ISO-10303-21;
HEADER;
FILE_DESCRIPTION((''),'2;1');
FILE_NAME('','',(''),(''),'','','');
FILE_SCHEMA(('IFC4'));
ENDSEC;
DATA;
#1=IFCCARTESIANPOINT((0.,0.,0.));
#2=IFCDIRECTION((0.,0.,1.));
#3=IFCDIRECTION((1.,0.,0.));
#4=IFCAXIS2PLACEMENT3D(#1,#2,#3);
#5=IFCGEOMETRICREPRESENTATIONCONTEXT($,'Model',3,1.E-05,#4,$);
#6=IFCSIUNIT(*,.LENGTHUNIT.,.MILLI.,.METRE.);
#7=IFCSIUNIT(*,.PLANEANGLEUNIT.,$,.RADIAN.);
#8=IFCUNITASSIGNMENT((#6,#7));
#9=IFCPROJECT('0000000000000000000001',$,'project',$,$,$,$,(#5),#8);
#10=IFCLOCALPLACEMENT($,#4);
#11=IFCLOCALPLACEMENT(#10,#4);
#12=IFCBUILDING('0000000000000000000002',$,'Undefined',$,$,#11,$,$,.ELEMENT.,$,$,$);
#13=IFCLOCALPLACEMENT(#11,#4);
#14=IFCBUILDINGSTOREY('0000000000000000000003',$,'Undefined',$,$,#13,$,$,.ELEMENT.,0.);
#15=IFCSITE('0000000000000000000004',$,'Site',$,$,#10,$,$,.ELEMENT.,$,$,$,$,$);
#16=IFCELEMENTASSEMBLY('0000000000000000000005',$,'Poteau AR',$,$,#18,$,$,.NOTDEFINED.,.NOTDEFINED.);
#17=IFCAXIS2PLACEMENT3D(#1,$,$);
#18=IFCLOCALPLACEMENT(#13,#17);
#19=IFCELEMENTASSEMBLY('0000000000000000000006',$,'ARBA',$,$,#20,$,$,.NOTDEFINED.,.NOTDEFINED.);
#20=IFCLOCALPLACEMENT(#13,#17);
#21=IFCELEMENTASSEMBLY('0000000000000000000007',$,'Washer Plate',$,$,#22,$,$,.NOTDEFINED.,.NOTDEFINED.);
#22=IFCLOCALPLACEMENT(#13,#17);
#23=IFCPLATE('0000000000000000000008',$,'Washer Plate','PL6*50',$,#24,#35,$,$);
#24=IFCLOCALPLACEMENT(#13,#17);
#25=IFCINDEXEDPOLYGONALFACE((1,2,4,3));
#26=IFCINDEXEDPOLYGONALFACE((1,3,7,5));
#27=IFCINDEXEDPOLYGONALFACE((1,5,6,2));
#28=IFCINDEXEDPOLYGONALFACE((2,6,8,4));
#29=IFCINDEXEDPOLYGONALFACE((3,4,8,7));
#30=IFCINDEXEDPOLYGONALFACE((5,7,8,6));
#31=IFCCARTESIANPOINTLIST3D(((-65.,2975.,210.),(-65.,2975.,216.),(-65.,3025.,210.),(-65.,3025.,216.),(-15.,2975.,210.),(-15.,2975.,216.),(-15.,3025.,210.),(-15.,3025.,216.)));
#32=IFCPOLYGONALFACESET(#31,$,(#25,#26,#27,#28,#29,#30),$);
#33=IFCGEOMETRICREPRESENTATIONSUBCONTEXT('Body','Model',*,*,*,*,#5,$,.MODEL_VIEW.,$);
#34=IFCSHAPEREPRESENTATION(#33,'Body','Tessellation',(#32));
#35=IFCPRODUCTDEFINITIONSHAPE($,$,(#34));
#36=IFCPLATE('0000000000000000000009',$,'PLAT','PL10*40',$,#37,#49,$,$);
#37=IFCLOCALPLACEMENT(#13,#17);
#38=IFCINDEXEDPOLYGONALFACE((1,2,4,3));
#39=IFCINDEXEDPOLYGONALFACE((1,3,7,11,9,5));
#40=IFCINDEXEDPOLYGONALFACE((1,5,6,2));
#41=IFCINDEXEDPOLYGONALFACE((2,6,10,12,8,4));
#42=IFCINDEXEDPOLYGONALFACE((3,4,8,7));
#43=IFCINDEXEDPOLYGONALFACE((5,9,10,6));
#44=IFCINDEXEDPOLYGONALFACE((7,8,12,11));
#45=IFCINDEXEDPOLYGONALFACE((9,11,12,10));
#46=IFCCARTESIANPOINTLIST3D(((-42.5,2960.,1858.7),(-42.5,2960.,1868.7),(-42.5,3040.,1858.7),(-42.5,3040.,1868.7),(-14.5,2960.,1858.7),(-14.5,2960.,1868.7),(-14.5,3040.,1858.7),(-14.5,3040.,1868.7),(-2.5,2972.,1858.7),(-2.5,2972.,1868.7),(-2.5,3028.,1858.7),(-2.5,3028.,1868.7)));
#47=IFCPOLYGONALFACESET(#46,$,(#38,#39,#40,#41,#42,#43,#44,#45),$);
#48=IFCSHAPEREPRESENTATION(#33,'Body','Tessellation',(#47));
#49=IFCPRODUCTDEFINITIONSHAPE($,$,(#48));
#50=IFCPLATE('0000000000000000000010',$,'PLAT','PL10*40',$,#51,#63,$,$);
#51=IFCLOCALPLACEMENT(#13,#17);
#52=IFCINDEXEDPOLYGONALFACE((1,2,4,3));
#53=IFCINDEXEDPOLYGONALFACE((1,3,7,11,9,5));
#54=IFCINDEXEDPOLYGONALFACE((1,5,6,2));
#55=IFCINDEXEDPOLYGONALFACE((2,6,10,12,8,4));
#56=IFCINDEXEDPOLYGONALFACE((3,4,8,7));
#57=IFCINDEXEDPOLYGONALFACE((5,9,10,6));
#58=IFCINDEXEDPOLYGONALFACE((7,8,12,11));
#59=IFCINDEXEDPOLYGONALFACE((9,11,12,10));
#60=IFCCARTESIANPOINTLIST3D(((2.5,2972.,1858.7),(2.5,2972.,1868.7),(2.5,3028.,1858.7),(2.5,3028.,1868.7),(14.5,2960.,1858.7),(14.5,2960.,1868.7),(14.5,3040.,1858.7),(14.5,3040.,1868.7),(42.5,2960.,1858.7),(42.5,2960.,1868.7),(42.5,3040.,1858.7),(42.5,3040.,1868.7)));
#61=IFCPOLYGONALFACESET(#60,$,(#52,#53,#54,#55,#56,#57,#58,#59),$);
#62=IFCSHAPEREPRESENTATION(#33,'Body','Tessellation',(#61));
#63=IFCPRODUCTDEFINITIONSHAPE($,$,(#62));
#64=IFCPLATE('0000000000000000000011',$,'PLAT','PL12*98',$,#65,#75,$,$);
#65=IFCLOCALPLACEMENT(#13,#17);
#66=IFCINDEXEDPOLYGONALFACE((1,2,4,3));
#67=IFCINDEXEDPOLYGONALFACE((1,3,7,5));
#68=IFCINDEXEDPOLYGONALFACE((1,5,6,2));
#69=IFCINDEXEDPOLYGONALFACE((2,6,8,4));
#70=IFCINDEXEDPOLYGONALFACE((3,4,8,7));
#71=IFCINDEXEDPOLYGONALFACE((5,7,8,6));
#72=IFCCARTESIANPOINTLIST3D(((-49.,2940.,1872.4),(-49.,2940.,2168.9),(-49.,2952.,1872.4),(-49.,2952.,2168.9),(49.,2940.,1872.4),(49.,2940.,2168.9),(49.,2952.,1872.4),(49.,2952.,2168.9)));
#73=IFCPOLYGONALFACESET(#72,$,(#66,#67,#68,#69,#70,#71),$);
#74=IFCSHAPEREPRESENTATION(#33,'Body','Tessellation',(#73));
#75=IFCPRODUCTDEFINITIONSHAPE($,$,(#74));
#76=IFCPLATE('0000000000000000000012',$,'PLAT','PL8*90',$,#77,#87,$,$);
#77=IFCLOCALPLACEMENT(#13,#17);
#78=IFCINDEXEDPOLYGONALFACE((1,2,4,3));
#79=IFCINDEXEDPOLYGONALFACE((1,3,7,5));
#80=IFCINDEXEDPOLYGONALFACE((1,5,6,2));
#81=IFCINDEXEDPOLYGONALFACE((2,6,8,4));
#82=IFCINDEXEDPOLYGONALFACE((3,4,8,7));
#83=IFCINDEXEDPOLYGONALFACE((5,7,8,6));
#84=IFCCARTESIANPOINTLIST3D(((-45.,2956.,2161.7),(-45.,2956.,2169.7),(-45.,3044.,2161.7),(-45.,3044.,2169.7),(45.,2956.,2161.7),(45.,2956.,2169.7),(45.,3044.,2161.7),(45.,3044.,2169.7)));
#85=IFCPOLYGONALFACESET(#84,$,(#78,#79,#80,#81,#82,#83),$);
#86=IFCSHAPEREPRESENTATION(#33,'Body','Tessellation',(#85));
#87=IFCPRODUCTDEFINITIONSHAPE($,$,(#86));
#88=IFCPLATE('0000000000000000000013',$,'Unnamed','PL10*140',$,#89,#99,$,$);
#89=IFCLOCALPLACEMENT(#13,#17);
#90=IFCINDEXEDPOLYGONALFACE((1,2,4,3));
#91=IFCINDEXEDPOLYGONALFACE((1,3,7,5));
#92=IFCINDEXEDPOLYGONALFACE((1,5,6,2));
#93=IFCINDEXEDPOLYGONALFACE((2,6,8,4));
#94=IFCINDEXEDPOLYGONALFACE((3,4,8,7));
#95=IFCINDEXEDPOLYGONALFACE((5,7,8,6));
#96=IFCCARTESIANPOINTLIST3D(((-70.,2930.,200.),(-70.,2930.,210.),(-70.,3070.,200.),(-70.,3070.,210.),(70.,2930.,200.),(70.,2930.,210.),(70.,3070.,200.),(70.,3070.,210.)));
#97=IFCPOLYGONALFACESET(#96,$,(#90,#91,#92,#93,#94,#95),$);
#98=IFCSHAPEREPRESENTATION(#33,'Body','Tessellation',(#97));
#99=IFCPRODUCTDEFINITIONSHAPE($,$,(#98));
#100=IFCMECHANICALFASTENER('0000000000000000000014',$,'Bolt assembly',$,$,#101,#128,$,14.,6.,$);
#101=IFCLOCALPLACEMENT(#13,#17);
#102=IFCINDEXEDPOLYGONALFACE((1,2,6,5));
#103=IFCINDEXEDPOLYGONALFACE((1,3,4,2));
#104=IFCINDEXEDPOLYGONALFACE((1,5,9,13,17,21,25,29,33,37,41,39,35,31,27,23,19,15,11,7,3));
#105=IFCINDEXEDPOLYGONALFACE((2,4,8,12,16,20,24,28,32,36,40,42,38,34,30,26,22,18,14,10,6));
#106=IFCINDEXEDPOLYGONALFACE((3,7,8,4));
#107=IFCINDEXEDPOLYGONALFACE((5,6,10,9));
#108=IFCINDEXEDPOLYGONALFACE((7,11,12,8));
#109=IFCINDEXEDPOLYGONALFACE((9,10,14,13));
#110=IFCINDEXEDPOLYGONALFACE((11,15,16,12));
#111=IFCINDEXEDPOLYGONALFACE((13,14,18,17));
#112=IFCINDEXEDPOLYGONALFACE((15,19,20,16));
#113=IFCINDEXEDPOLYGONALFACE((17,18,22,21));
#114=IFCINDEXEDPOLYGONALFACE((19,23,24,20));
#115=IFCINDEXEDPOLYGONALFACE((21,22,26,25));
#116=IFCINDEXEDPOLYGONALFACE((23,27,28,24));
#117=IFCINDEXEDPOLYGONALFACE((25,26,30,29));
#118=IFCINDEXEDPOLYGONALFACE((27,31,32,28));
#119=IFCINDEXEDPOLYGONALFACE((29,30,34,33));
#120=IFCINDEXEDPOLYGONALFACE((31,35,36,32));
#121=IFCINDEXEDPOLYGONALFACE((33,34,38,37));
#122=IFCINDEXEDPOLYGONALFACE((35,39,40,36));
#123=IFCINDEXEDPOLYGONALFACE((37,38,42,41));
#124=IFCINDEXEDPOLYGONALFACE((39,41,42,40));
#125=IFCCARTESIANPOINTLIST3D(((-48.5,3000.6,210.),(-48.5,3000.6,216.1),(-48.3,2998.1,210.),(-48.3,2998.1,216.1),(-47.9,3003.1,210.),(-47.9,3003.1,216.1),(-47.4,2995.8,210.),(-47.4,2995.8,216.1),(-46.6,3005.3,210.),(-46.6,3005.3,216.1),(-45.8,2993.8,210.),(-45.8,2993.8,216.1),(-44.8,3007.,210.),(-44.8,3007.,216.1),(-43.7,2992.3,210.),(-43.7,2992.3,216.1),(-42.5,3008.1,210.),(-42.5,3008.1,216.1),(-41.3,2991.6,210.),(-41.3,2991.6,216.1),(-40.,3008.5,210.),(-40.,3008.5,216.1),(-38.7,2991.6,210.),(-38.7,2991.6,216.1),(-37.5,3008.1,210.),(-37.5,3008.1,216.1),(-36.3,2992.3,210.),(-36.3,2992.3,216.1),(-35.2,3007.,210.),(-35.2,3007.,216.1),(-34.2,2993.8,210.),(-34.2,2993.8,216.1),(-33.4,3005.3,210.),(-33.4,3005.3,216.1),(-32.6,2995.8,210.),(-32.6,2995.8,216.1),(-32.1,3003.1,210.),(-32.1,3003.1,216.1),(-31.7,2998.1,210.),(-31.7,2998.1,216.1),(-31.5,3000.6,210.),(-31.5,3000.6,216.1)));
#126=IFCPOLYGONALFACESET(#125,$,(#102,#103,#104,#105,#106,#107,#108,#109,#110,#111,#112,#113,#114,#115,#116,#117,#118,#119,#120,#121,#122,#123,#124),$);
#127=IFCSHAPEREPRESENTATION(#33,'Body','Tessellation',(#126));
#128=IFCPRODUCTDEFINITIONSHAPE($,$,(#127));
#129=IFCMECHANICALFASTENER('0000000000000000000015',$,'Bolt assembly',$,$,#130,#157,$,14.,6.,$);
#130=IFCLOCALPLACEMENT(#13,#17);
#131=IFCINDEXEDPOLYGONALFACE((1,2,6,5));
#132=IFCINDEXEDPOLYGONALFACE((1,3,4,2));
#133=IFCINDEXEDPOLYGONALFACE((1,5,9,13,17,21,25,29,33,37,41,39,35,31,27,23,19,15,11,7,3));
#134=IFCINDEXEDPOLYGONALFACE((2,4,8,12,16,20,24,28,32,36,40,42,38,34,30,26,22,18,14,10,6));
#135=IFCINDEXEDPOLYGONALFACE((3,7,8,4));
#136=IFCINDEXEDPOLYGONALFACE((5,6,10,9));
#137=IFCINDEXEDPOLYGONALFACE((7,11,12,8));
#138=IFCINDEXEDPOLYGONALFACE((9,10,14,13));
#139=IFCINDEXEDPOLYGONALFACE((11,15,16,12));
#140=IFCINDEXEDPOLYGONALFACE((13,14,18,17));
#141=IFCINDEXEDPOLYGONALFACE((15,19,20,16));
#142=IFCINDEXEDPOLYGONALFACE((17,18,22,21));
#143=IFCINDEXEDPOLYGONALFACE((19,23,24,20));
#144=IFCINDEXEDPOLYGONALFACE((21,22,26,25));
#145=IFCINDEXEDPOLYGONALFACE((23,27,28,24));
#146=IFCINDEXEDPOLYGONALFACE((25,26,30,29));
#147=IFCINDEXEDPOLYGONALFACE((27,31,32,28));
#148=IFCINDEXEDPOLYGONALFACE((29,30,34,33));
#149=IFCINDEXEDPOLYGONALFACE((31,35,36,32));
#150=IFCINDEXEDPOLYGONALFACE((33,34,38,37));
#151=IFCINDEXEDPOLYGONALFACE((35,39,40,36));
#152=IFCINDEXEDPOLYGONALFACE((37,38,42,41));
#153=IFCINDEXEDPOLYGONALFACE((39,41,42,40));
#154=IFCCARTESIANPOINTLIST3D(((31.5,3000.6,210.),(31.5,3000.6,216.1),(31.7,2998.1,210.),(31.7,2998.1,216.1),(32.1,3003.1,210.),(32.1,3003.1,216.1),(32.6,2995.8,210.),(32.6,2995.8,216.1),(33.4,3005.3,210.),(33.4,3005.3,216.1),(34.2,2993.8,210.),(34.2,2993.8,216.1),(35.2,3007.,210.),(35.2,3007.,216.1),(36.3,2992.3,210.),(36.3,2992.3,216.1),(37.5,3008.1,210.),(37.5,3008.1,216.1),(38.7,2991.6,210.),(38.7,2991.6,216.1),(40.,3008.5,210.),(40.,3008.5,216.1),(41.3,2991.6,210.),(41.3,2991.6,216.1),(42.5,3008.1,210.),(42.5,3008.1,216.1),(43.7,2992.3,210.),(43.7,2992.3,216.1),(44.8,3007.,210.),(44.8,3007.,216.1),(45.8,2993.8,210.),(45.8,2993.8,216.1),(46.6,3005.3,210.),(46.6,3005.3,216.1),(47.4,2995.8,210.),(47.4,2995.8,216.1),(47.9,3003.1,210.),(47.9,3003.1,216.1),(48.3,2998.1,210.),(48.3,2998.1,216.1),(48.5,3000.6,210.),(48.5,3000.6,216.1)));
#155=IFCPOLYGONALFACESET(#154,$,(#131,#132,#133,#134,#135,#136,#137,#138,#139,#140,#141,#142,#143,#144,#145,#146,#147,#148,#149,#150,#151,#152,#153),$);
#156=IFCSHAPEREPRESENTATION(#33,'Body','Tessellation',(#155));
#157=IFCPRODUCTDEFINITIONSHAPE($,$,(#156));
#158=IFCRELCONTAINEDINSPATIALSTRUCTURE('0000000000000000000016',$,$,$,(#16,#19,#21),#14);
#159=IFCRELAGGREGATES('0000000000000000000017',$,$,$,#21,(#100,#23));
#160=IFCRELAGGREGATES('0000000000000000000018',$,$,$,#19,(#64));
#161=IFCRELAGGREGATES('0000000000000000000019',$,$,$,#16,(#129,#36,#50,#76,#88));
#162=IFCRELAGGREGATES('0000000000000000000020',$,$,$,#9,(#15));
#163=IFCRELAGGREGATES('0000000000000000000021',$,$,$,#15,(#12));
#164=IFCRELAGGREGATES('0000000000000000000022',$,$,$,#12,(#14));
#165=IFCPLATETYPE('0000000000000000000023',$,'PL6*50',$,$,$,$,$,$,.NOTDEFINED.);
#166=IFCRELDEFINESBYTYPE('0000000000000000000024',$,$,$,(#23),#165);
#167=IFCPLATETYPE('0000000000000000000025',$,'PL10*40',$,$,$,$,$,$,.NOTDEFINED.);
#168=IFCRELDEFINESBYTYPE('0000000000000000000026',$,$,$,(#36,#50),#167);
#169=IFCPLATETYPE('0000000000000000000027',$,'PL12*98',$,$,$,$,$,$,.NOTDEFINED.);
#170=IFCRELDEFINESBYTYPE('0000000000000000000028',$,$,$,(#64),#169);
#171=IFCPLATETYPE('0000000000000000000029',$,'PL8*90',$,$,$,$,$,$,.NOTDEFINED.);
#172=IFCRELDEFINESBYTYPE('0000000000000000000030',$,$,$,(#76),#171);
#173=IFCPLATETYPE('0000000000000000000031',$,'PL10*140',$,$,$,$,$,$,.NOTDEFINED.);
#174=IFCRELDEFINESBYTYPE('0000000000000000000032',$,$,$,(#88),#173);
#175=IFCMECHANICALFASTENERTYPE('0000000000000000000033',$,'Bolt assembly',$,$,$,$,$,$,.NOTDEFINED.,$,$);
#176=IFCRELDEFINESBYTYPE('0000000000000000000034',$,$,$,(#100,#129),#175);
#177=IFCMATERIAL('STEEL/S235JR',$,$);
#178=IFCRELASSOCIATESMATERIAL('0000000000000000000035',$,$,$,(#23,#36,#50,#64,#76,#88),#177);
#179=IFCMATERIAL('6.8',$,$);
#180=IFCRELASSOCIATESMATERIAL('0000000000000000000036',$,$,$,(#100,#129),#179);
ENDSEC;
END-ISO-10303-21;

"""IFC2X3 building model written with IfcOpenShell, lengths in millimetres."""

from ifc_helpers import new_model, si_unit, frame, origin_with_axes, origin_2d_with_axis, place, context, subcontext, project, spatial, polyline, circle, outline, extrude, source, transform, mapped, material, type_object, element, aggregate, save


model = new_model("IFC2X3")

# Units and contexts
model_context = context("Model", 3, precision=1e-05, world=origin_with_axes())
body_context = subcontext(model_context, "Body", "Model", "MODEL_VIEW")
ifc_project = project(units=[si_unit("LENGTHUNIT", "METRE", prefix="MILLI"), si_unit("PLANEANGLEUNIT", "RADIAN")], contexts=[model_context])

# Site, building, storey
site_placement = place(None, origin_with_axes())
site = spatial("IfcSite", under=ifc_project, at=site_placement, Name="Site", CompositionType="ELEMENT")
building_placement = place(site_placement, origin_with_axes())
building = spatial("IfcBuilding", under=site, at=building_placement, Name="Undefined", CompositionType="ELEMENT")
storey_placement = place(building_placement, origin_with_axes())
storey = spatial("IfcBuildingStorey", under=building, at=storey_placement, Name="Undefined", CompositionType="ELEMENT", Elevation=0.0)

# Element assembly
ifc_material_1 = material(Name="STEEL/S235JR")
assembly_1_placement = place(storey_placement, origin_with_axes())
assembly_1 = element("IfcElementAssembly", 1, at=assembly_1_placement, inside=storey, Name="Poteau AR", AssemblyPlace="NOTDEFINED", PredefinedType="NOTDEFINED")

# Element assembly
assembly_2_placement = place(storey_placement, origin_with_axes())
assembly_2 = element("IfcElementAssembly", 2, at=assembly_2_placement, inside=storey, Name="ARBA", AssemblyPlace="NOTDEFINED", PredefinedType="NOTDEFINED")

# Element assembly, plate
assembly_3_placement = place(storey_placement, origin_with_axes())
assembly_3 = element("IfcElementAssembly", 3, at=assembly_3_placement, inside=storey, Name="Washer Plate", AssemblyPlace="NOTDEFINED", PredefinedType="NOTDEFINED")
plate_type_1 = type_object("IfcPlateType", Name="PL6*50", PredefinedType="NOTDEFINED")
plate_1_placement = place(assembly_3_placement, frame((-15.0, 3025.0, 213.0), z_axis=(0.0, 0.0, -1.0), x_axis=(0.0, -1.0, 0.0)))
plate_1 = element("IfcPlate", 4, at=plate_1_placement, type_object=plate_type_1, material=ifc_material_1, Name="Washer Plate", Description="PL6*50", context=body_context, shape_type="SweptSolid", body=[
    extrude(outline(polyline([(0.0, 0.0), (50.0, 0.0), (50.0, 50.0), (0.0, 50.0), (0.0, 0.0)])), frame((0.0, 0.0, -3.0), z_axis=(0.0, 0.0, 1.0), x_axis=(1.0, 0.0, 0.0)), (0.0, 0.0, 1.0), 6.0),
])

# Plates
plate_type_2 = type_object("IfcPlateType", Name="PL10*40", PredefinedType="NOTDEFINED")
plate_2_placement = place(assembly_1_placement, frame((-42.5, 2960.0, 1863.7), z_axis=(0.0, 0.0, 1.0), x_axis=(1.0, 0.0, 0.0)))
plate_2 = element("IfcPlate", 5, at=plate_2_placement, type_object=plate_type_2, material=ifc_material_1, Name="PLAT", Description="PL10*40", context=body_context, shape_type="SweptSolid", body=[
    extrude(outline(polyline([(0.0, 0.0), (28.0, 0.0), (40.0, 12.0), (40.0, 68.0), (28.0, 80.0), (0.0, 80.0), (0.0, 0.0)])), frame((0.0, 0.0, -5.0), z_axis=(0.0, 0.0, 1.0), x_axis=(1.0, 0.0, 0.0)), (0.0, 0.0, 1.0), 10.0),
])
plate_3_placement = place(assembly_1_placement, frame((42.5, 2960.0, 1863.7), z_axis=(0.0, 0.0, -1.0), x_axis=(-1.0, 0.0, 0.0)))
plate_3 = element("IfcPlate", 6, at=plate_3_placement, type_object=plate_type_2, material=ifc_material_1, Name="PLAT", Description="PL10*40", context=body_context, shape_type="SweptSolid", body=[
    extrude(outline(polyline([(0.0, 0.0), (28.0, 0.0), (40.0, 12.0), (40.0, 68.0), (28.0, 80.0), (0.0, 80.0), (0.0, 0.0)])), frame((0.0, 0.0, -5.0), z_axis=(0.0, 0.0, 1.0), x_axis=(1.0, 0.0, 0.0)), (0.0, 0.0, 1.0), 10.0),
])
plate_type_3 = type_object("IfcPlateType", Name="PL12*98", PredefinedType="NOTDEFINED")
plate_4_placement = place(assembly_2_placement, frame((0.0, 2946.0, 1872.4), z_axis=(0.0, -1.0, 0.0), x_axis=(0.0, 0.0, 1.0)))
plate_4 = element("IfcPlate", 7, at=plate_4_placement, type_object=plate_type_3, material=ifc_material_1, Name="PLAT", Description="PL12*98", context=body_context, shape_type="SweptSolid", body=[
    extrude(outline(polyline([(0.0, 49.0), (296.4, 49.0), (296.4, -49.0), (0.0, -49.0), (0.0, 49.0)])), frame((0.0, 0.0, -6.0), z_axis=(0.0, 0.0, 1.0), x_axis=(1.0, 0.0, 0.0)), (0.0, 0.0, 1.0), 12.0),
])
plate_type_4 = type_object("IfcPlateType", Name="PL8*90", PredefinedType="NOTDEFINED")
plate_5_placement = place(assembly_1_placement, frame((0.0, 3044.0, 2165.7), z_axis=(0.0, 0.0, -1.0), x_axis=(0.0, -1.0, 0.0)))
plate_5 = element("IfcPlate", 8, at=plate_5_placement, type_object=plate_type_4, material=ifc_material_1, Name="PLAT", Description="PL8*90", context=body_context, shape_type="SweptSolid", body=[
    extrude(outline(polyline([(88.0, 45.0), (88.0, -45.0), (0.0, -45.0), (0.0, 45.0), (88.0, 45.0)])), frame((0.0, 0.0, -4.0), z_axis=(0.0, 0.0, 1.0), x_axis=(1.0, 0.0, 0.0)), (0.0, 0.0, 1.0), 8.0),
])
plate_type_5 = type_object("IfcPlateType", Name="PL10*140", PredefinedType="NOTDEFINED")
plate_6_placement = place(assembly_1_placement, frame((0.0, 2930.0, 205.0), z_axis=(0.0, 0.0, 1.0), x_axis=(0.0, 1.0, 0.0)))
plate_6 = element("IfcPlate", 9, at=plate_6_placement, type_object=plate_type_5, material=ifc_material_1, Name="Unnamed", Description="PL10*140", context=body_context, shape_type="SweptSolid", body=[
    extrude(outline(polyline([(0.0, 70.0), (140.0, 70.0), (140.0, -70.0), (0.0, -70.0), (0.0, 70.0)])), frame((0.0, 0.0, -5.0), z_axis=(0.0, 0.0, 1.0), x_axis=(1.0, 0.0, 0.0)), (0.0, 0.0, 1.0), 10.0),
])

# Mechanical fasteners
ifc_material_2 = material(Name="6.8")
mechanical_fastener_type = type_object("IfcMechanicalFastenerType", Name="Bolt assembly")
shared_shape_1 = source(origin_with_axes(), body_context, "Body", "SweptSolid", [
    extrude(circle(Radius=8.5, at=origin_2d_with_axis()), frame((0.0, 0.0, 0.0), z_axis=(0.0, 1.0, 0.0), x_axis=(1.0, 0.0, 0.0)), (0.0, 0.0, 1.0), 6.1),
])
mechanical_fastener_1_placement = place(assembly_3_placement, frame((-40.0, 3000.0, 210.0), z_axis=(1.0, 0.0, 0.0), x_axis=(0.0, 1.0, 0.0)))
mechanical_fastener_1 = element("IfcMechanicalFastener", 10, at=mechanical_fastener_1_placement, type_object=mechanical_fastener_type, material=ifc_material_2, Name="Bolt assembly", NominalDiameter=14.0, NominalLength=6.0, context=body_context, shape_type="MappedRepresentation", body=[
    mapped(shared_shape_1, transform((0.0, 0.0, 0.0))),
])
aggregate(assembly_3, [mechanical_fastener_1, plate_1])
mechanical_fastener_2_placement = place(assembly_1_placement, frame((40.0, 3000.0, 210.0), z_axis=(1.0, 0.0, 0.0), x_axis=(0.0, 1.0, 0.0)))
mechanical_fastener_2 = element("IfcMechanicalFastener", 11, at=mechanical_fastener_2_placement, type_object=mechanical_fastener_type, material=ifc_material_2, Name="Bolt assembly", NominalDiameter=14.0, NominalLength=6.0, context=body_context, shape_type="MappedRepresentation", body=[
    mapped(shared_shape_1, transform((0.0, 0.0, 0.0))),
])
aggregate(assembly_2, [plate_4])
aggregate(assembly_1, [mechanical_fastener_2, plate_2, plate_3, plate_5, plate_6])

save(model, "model.ifc")
